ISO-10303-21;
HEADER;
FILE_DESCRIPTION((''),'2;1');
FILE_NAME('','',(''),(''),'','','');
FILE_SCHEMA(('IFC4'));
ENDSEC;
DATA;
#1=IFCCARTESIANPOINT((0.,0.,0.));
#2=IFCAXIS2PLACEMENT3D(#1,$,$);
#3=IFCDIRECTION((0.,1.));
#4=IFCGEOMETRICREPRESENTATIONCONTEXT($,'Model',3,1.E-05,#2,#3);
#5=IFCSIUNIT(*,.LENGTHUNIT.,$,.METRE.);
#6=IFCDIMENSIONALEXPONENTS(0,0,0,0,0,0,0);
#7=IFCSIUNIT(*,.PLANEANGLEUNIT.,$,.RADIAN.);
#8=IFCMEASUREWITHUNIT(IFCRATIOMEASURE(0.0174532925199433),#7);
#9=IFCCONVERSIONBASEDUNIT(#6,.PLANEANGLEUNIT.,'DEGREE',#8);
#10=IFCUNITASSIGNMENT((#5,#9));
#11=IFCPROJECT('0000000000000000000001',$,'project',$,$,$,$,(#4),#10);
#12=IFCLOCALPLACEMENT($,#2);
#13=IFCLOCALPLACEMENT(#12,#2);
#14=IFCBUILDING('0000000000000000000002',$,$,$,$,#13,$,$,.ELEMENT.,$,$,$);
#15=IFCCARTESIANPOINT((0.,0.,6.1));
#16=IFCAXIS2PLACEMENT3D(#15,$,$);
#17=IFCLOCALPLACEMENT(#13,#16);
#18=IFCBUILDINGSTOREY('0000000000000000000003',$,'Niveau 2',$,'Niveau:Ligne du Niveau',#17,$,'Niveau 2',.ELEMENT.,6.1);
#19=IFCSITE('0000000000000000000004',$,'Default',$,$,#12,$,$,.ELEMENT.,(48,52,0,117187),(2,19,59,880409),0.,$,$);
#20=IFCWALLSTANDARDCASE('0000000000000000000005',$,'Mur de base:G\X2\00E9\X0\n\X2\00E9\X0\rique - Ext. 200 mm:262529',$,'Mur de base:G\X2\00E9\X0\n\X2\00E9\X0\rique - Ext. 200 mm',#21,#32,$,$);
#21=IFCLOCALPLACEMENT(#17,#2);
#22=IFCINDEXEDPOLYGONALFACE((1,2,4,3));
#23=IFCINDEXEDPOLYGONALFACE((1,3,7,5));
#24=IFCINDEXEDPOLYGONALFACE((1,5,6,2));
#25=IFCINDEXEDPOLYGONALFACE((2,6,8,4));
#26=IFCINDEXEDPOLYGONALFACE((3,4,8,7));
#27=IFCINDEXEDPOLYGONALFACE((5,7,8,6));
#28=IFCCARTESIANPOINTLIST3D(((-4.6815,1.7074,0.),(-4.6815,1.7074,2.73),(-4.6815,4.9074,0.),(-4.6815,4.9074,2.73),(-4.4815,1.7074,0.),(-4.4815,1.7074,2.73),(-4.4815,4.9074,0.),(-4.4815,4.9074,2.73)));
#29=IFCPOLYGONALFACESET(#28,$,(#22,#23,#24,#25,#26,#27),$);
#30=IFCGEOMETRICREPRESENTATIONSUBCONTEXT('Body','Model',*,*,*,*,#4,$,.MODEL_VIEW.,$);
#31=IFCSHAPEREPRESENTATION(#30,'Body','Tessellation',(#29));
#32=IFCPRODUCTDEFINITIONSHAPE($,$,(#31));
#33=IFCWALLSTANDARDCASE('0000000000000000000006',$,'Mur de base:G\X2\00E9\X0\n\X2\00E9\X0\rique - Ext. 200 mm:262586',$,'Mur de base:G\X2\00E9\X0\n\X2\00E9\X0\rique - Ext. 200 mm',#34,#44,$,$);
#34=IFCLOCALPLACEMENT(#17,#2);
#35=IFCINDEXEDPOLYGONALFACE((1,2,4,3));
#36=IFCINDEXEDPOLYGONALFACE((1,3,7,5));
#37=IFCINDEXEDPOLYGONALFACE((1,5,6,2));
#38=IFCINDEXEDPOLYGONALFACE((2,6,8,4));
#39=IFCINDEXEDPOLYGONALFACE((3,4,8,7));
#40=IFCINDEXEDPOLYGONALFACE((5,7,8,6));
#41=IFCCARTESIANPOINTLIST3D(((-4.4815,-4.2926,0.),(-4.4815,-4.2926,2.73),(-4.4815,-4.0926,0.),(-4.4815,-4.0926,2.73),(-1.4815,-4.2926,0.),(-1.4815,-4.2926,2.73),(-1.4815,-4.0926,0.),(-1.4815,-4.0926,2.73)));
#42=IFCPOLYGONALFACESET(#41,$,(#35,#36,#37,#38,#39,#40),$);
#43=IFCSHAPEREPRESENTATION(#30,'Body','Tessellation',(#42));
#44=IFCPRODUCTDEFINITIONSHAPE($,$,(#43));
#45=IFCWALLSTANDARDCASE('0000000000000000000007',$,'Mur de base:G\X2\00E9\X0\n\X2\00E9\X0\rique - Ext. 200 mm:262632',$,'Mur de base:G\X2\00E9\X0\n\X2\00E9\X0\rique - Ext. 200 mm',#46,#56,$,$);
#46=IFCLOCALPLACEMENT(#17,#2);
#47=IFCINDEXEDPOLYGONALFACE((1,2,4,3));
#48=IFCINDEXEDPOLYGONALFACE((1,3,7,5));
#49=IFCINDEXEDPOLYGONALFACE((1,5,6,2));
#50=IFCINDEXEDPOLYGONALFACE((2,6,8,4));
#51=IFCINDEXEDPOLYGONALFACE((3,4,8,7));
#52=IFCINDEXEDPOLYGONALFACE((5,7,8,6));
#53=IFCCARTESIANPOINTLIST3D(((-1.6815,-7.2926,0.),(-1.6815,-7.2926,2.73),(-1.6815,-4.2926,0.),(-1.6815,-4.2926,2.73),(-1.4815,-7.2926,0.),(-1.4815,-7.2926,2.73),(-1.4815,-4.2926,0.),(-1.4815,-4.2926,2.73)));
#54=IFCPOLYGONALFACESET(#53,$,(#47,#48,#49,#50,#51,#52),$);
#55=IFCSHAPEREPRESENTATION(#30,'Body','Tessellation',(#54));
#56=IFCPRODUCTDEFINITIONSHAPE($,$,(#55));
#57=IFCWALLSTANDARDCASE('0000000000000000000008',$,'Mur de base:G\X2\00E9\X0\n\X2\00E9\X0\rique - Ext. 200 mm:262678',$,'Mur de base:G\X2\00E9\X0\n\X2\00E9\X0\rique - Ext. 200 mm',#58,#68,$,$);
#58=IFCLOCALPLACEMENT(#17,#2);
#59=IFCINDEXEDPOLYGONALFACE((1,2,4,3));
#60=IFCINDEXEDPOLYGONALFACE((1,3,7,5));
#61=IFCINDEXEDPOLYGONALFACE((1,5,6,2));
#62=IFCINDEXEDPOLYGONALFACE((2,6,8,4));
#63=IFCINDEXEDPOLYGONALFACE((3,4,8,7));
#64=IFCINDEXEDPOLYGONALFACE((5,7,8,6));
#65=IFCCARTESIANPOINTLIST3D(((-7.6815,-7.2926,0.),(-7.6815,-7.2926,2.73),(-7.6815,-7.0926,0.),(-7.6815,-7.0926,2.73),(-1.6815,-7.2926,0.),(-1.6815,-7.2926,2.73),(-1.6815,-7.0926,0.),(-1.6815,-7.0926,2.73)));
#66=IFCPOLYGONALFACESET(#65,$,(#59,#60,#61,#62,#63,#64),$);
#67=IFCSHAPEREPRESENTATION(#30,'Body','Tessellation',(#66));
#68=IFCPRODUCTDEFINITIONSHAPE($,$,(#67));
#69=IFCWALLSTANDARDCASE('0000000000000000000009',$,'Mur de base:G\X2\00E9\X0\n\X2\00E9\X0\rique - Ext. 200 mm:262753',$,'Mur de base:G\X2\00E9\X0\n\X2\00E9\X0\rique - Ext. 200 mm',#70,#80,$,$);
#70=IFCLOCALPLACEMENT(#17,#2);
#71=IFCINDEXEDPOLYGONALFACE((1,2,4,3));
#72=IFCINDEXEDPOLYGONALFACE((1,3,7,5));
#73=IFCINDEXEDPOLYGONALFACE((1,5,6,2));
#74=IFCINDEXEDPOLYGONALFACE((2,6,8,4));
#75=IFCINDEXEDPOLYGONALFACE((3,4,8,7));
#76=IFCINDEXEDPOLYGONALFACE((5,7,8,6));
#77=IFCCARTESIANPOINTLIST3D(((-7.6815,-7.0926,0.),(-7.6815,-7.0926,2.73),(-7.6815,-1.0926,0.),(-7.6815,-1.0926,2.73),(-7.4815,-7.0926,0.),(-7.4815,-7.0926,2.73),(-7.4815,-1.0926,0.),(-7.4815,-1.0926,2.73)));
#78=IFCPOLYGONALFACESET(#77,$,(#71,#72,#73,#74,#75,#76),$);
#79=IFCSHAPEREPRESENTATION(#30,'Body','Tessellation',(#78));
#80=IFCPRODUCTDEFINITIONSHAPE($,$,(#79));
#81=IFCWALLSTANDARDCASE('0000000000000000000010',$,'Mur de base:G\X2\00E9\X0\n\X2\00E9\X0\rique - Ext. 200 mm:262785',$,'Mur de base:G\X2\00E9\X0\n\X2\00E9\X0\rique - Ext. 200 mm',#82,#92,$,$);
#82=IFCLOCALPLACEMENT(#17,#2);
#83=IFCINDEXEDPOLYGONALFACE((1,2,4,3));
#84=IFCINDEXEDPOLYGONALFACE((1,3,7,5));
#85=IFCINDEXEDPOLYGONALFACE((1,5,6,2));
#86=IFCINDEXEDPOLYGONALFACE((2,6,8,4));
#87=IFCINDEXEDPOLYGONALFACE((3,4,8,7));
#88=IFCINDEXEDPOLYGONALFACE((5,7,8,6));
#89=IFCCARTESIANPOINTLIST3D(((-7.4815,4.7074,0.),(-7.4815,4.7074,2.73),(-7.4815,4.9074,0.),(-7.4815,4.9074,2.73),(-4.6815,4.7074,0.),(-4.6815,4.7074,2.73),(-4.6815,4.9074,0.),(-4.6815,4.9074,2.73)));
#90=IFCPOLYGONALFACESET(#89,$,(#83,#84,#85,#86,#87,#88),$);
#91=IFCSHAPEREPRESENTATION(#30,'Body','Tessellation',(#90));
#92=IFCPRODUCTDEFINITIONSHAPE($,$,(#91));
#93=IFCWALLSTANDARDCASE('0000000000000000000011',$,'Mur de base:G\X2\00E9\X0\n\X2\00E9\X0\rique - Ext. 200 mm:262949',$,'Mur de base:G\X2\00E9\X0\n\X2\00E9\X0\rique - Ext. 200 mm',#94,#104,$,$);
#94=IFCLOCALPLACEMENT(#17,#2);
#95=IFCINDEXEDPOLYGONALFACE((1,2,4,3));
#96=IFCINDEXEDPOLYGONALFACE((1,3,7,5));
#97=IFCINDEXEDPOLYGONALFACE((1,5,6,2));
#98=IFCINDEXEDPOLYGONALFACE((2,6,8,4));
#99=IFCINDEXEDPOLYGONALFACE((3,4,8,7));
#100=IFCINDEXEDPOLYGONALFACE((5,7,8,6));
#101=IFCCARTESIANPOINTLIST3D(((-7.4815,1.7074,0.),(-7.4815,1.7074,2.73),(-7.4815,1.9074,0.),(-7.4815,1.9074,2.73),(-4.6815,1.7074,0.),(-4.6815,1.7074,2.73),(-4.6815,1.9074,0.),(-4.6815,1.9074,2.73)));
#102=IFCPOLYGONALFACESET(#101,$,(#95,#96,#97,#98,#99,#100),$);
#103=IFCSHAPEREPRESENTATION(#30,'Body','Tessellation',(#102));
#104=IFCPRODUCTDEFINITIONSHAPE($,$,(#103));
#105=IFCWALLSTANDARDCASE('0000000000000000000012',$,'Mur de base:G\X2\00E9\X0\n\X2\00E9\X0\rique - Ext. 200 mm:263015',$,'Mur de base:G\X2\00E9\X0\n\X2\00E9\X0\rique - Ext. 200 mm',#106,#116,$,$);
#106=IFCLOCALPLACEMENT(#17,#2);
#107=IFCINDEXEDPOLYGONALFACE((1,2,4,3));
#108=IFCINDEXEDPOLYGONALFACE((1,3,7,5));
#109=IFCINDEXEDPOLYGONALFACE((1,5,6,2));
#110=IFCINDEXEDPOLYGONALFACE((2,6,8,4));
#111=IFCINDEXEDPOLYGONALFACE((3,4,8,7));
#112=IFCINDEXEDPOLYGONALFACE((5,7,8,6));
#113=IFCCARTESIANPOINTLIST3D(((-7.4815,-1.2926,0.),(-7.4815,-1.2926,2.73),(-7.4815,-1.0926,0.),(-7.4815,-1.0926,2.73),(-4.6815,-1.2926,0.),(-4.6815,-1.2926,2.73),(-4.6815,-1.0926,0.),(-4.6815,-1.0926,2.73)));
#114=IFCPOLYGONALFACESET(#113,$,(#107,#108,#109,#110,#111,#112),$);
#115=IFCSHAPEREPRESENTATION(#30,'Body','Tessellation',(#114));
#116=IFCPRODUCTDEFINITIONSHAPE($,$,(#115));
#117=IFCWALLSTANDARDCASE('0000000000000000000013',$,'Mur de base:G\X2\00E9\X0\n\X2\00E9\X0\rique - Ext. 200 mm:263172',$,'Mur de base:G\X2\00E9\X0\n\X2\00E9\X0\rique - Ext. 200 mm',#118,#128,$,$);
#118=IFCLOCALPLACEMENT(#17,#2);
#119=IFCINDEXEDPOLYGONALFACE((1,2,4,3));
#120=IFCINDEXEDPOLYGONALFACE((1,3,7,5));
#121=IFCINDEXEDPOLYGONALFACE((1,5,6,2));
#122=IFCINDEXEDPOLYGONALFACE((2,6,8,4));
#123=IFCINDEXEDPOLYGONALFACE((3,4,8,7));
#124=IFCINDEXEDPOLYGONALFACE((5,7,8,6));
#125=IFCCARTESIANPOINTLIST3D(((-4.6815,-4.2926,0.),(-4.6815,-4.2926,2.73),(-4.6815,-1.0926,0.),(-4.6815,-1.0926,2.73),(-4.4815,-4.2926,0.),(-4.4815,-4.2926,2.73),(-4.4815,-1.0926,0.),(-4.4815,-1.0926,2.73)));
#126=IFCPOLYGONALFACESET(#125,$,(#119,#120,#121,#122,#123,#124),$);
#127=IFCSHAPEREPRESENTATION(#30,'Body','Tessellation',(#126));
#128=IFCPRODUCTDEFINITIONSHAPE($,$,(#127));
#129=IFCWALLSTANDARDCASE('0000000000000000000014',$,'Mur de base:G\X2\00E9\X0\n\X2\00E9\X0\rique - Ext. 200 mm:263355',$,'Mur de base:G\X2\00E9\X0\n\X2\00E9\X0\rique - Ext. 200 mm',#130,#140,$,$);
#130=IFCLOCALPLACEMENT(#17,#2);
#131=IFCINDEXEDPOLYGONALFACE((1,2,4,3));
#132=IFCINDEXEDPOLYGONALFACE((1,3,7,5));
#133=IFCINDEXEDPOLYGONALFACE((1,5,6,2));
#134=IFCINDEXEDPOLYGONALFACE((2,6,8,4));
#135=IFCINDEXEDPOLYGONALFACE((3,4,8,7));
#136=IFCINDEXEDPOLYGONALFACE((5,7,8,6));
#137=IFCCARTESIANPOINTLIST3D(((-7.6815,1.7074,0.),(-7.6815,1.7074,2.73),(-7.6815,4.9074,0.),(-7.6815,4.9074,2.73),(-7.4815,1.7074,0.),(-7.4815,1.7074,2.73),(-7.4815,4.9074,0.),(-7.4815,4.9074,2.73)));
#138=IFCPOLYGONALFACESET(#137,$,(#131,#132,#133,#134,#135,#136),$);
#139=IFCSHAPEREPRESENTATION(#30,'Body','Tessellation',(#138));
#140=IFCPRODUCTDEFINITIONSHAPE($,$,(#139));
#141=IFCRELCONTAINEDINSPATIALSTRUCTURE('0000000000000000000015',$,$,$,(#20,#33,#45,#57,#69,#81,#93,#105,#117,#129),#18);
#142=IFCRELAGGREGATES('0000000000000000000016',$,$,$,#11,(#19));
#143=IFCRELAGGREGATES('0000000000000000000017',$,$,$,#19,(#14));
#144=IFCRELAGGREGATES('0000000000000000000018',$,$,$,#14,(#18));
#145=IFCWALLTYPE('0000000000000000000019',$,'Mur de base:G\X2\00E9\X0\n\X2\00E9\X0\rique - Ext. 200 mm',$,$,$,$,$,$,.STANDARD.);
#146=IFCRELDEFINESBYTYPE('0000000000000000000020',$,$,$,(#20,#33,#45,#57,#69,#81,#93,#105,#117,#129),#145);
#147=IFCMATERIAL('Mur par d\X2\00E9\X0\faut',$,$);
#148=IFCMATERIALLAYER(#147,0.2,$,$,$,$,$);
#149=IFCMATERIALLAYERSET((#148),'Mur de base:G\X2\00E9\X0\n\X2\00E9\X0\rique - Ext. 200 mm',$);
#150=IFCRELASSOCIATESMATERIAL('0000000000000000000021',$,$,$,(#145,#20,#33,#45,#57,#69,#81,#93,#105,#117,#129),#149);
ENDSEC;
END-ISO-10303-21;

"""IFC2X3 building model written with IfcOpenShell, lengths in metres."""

from ifc_helpers import new_model, entity, si_unit, converted_unit, direction, frame, frame_2d, origin, place, context, subcontext, project, spatial, polyline, rectangle, extrude, clip, bounded_halfspace, material, layer, layer_set, layer_usage, type_object, element, save


model = new_model("IFC2X3")

# Units and contexts
model_context = context("Model", 3, precision=1e-05, world=origin(), true_north=direction((0.0, 1.0)))
body_context = subcontext(model_context, "Body", "Model", "MODEL_VIEW")
ifc_project = project(units=[si_unit("LENGTHUNIT", "METRE"), converted_unit("PLANEANGLEUNIT", "DEGREE", entity("IfcRatioMeasure", 0.0174532925199433), si_unit("PLANEANGLEUNIT", "RADIAN"), dimensions=[0, 0, 0, 0, 0, 0, 0])], contexts=[model_context])

# Site, building, storey
site_placement = place(None, origin())
site = spatial("IfcSite", under=ifc_project, at=site_placement, Name="Default", CompositionType="ELEMENT", RefLatitude=(48, 52, 0, 117187), RefLongitude=(2, 19, 59, 880409), RefElevation=0.0)
building_placement = place(site_placement, origin())
building = spatial("IfcBuilding", under=site, at=building_placement, CompositionType="ELEMENT")
storey_placement = place(building_placement, frame((0.0, 0.0, 6.1)))
storey = spatial("IfcBuildingStorey", under=building, at=storey_placement, Name="Niveau 2", ObjectType="Niveau:Ligne du Niveau", LongName="Niveau 2", CompositionType="ELEMENT", Elevation=6.1)

# Walls
ifc_material_1 = material(Name="Mur par défaut")
ifc_layer_1 = layer(ifc_material_1, 0.2)
ifc_layer_set_1 = layer_set([ifc_layer_1], Name="Mur de base:Générique - Ext. 200 mm")
ifc_layer_usage_1 = layer_usage(ifc_layer_set_1, "AXIS2", "NEGATIVE", 0.1)
wall_type = type_object("IfcWallType", Name="Mur de base:Générique - Ext. 200 mm", PredefinedType="STANDARD", material=ifc_layer_set_1)
wall_1_placement = place(storey_placement, frame((-4.5815, 4.9074, 0.0), z_axis=(0.0, 0.0, 1.0), x_axis=(0.0, -1.0, 0.0)))
element("IfcWallStandardCase", 1, at=wall_1_placement, inside=storey, type_object=wall_type, material=ifc_layer_usage_1, Name="Mur de base:Générique - Ext. 200 mm:262529", ObjectType="Mur de base:Générique - Ext. 200 mm", context=body_context, shape_type="Clipping", body=[
    clip(extrude(rectangle(XDim=3.2, YDim=0.2, at=frame_2d((1.6, 0.0), x_axis=(-1.0, 0.0))), origin(), (0.0, 0.0, 1.0), 2.73), bounded_halfspace(frame((0.0, -0.1, 2.73), z_axis=(0.0, 0.0, -1.0), x_axis=(1.0, 0.0, 0.0)), True, frame((0.0, -0.1, 2.73)), polyline([(0.0, 0.0), (0.2, 0.0), (3.0, 0.0), (3.2, 0.0), (3.2, 0.2), (0.0, 0.2), (0.0, 0.0)]))),
])
ifc_layer_usage_2 = layer_usage(ifc_layer_set_1, "AXIS2", "NEGATIVE", 0.1)
wall_2_placement = place(storey_placement, frame((-4.4815, -4.1926, 0.0)))
element("IfcWallStandardCase", 2, at=wall_2_placement, inside=storey, type_object=wall_type, material=ifc_layer_usage_2, Name="Mur de base:Générique - Ext. 200 mm:262586", ObjectType="Mur de base:Générique - Ext. 200 mm", context=body_context, shape_type="Clipping", body=[
    clip(extrude(rectangle(XDim=3.0, YDim=0.2, at=frame_2d((1.5, 0.0), x_axis=(-1.0, 0.0))), origin(), (0.0, 0.0, 1.0), 2.73), bounded_halfspace(frame((0.0, -0.1, 2.73), z_axis=(0.0, 0.0, -1.0), x_axis=(0.0, -1.0, 0.0)), True, frame((0.0, -0.1, 2.73)), polyline([(0.0, 0.0), (2.8, 0.0), (3.0, 0.0), (3.0, 0.2), (1.4, 0.2), (0.0, 0.2), (0.0, 0.0)]))),
])
ifc_layer_usage_3 = layer_usage(ifc_layer_set_1, "AXIS2", "NEGATIVE", 0.1)
wall_3_placement = place(storey_placement, frame((-1.5815, -4.2926, 0.0), z_axis=(0.0, 0.0, 1.0), x_axis=(0.0, -1.0, 0.0)))
element("IfcWallStandardCase", 3, at=wall_3_placement, inside=storey, type_object=wall_type, material=ifc_layer_usage_3, Name="Mur de base:Générique - Ext. 200 mm:262632", ObjectType="Mur de base:Générique - Ext. 200 mm", context=body_context, shape_type="Clipping", body=[
    clip(extrude(rectangle(XDim=3.0, YDim=0.2, at=frame_2d((1.5, 0.0), x_axis=(-1.0, 0.0))), origin(), (0.0, 0.0, 1.0), 2.73), bounded_halfspace(frame((0.0, -0.1, 2.73), z_axis=(0.0, 0.0, -1.0), x_axis=(1.0, 0.0, 0.0)), True, frame((0.0, -0.1, 2.73)), polyline([(0.0, 0.0), (2.8, 0.0), (3.0, 0.0), (3.0, 0.2), (0.0, 0.2), (0.0, 0.0)]))),
])
ifc_layer_usage_4 = layer_usage(ifc_layer_set_1, "AXIS2", "NEGATIVE", 0.1)
wall_4_placement = place(storey_placement, frame((-1.6815, -7.1926, 0.0), z_axis=(0.0, 0.0, 1.0), x_axis=(-1.0, 0.0, 0.0)))
element("IfcWallStandardCase", 4, at=wall_4_placement, inside=storey, type_object=wall_type, material=ifc_layer_usage_4, Name="Mur de base:Générique - Ext. 200 mm:262678", ObjectType="Mur de base:Générique - Ext. 200 mm", context=body_context, shape_type="Clipping", body=[
    clip(extrude(rectangle(XDim=6.0, YDim=0.2, at=frame_2d((3.0, 0.0), x_axis=(-1.0, 0.0))), origin(), (0.0, 0.0, 1.0), 2.73), bounded_halfspace(frame((0.0, -0.1, 2.73), z_axis=(0.0, 0.0, -1.0), x_axis=(0.0, 1.0, 0.0)), True, frame((0.0, -0.1, 2.73)), polyline([(0.0, 0.0), (5.8, 0.0), (6.0, 0.0), (6.0, 0.2), (0.0, 0.2), (0.0, 0.0)]))),
])
ifc_layer_usage_5 = layer_usage(ifc_layer_set_1, "AXIS2", "NEGATIVE", 0.1)
wall_5_placement = place(storey_placement, frame((-7.5815, -7.0926, 0.0), z_axis=(0.0, 0.0, 1.0), x_axis=(0.0, 1.0, 0.0)))
element("IfcWallStandardCase", 5, at=wall_5_placement, inside=storey, type_object=wall_type, material=ifc_layer_usage_5, Name="Mur de base:Générique - Ext. 200 mm:262753", ObjectType="Mur de base:Générique - Ext. 200 mm", context=body_context, shape_type="Clipping", body=[
    clip(extrude(rectangle(XDim=6.0, YDim=0.2, at=frame_2d((3.0, 0.0), x_axis=(-1.0, 0.0))), origin(), (0.0, 0.0, 1.0), 2.73), bounded_halfspace(frame((0.0, -0.1, 2.73), z_axis=(0.0, 0.0, -1.0), x_axis=(-1.0, 0.0, 0.0)), True, frame((0.0, -0.1, 2.73)), polyline([(0.0, 0.0), (5.8, 0.0), (6.0, 0.0), (6.0, 0.2), (0.0, 0.2), (0.0, 0.0)]))),
])
ifc_layer_usage_6 = layer_usage(ifc_layer_set_1, "AXIS2", "NEGATIVE", 0.1)
wall_6_placement = place(storey_placement, frame((-7.4815, 4.8074, 0.0)))
element("IfcWallStandardCase", 6, at=wall_6_placement, inside=storey, type_object=wall_type, material=ifc_layer_usage_6, Name="Mur de base:Générique - Ext. 200 mm:262785", ObjectType="Mur de base:Générique - Ext. 200 mm", context=body_context, shape_type="Clipping", body=[
    clip(extrude(rectangle(XDim=2.8, YDim=0.2, at=frame_2d((1.4, 0.0), x_axis=(-1.0, 0.0))), origin(), (0.0, 0.0, 1.0), 2.73), bounded_halfspace(frame((0.0, -0.1, 2.73), z_axis=(0.0, 0.0, -1.0), x_axis=(0.0, -1.0, 0.0)), True, frame((0.0, -0.1, 2.73)), polyline([(0.0, 0.0), (2.8, 0.0), (2.8, 0.2), (0.0, 0.2), (0.0, 0.0)]))),
])
ifc_layer_usage_7 = layer_usage(ifc_layer_set_1, "AXIS2", "NEGATIVE", 0.1)
wall_7_placement = place(storey_placement, frame((-7.4815, 1.8074, 0.0)))
element("IfcWallStandardCase", 7, at=wall_7_placement, inside=storey, type_object=wall_type, material=ifc_layer_usage_7, Name="Mur de base:Générique - Ext. 200 mm:262949", ObjectType="Mur de base:Générique - Ext. 200 mm", context=body_context, shape_type="Clipping", body=[
    clip(extrude(rectangle(XDim=2.8, YDim=0.2, at=frame_2d((1.4, 0.0), x_axis=(-1.0, 0.0))), origin(), (0.0, 0.0, 1.0), 2.73), bounded_halfspace(frame((0.0, -0.1, 2.73), z_axis=(0.0, 0.0, -1.0), x_axis=(0.0, -1.0, 0.0)), True, frame((0.0, -0.1, 2.73)), polyline([(0.0, 0.0), (2.8, 0.0), (2.8, 0.2), (0.0, 0.2), (0.0, 0.0)]))),
])
ifc_layer_usage_8 = layer_usage(ifc_layer_set_1, "AXIS2", "NEGATIVE", 0.1)
wall_8_placement = place(storey_placement, frame((-7.4815, -1.1926, 0.0)))
element("IfcWallStandardCase", 8, at=wall_8_placement, inside=storey, type_object=wall_type, material=ifc_layer_usage_8, Name="Mur de base:Générique - Ext. 200 mm:263015", ObjectType="Mur de base:Générique - Ext. 200 mm", context=body_context, shape_type="Clipping", body=[
    clip(extrude(rectangle(XDim=2.8, YDim=0.2, at=frame_2d((1.4, 0.0), x_axis=(-1.0, 0.0))), origin(), (0.0, 0.0, 1.0), 2.73), bounded_halfspace(frame((0.0, -0.1, 2.73), z_axis=(0.0, 0.0, -1.0), x_axis=(0.0, -1.0, 0.0)), True, frame((0.0, -0.1, 2.73)), polyline([(0.0, 0.0), (2.8, 0.0), (2.8, 0.2), (0.0, 0.2), (0.0, 0.0)]))),
])
ifc_layer_usage_9 = layer_usage(ifc_layer_set_1, "AXIS2", "NEGATIVE", 0.1)
wall_9_placement = place(storey_placement, frame((-4.5815, -1.0926, 0.0), z_axis=(0.0, 0.0, 1.0), x_axis=(0.0, -1.0, 0.0)))
element("IfcWallStandardCase", 9, at=wall_9_placement, inside=storey, type_object=wall_type, material=ifc_layer_usage_9, Name="Mur de base:Générique - Ext. 200 mm:263172", ObjectType="Mur de base:Générique - Ext. 200 mm", context=body_context, shape_type="Clipping", body=[
    clip(extrude(rectangle(XDim=3.2, YDim=0.2, at=frame_2d((1.6, 0.0), x_axis=(-1.0, 0.0))), origin(), (0.0, 0.0, 1.0), 2.73), bounded_halfspace(frame((0.0, -0.1, 2.73), z_axis=(0.0, 0.0, -1.0), x_axis=(1.0, 0.0, 0.0)), True, frame((0.0, -0.1, 2.73)), polyline([(0.0, 0.0), (0.2, 0.0), (3.2, 0.0), (3.2, 0.2), (3.0, 0.2), (0.0, 0.2), (0.0, 0.0)]))),
])
ifc_layer_usage_10 = layer_usage(ifc_layer_set_1, "AXIS2", "NEGATIVE", 0.1)
wall_10_placement = place(storey_placement, frame((-7.5815, 1.7074, 0.0), z_axis=(0.0, 0.0, 1.0), x_axis=(0.0, 1.0, 0.0)))
element("IfcWallStandardCase", 10, at=wall_10_placement, inside=storey, type_object=wall_type, material=ifc_layer_usage_10, Name="Mur de base:Générique - Ext. 200 mm:263355", ObjectType="Mur de base:Générique - Ext. 200 mm", context=body_context, shape_type="Clipping", body=[
    clip(extrude(rectangle(XDim=3.2, YDim=0.2, at=frame_2d((1.6, 0.0), x_axis=(-1.0, 0.0))), origin(), (0.0, 0.0, 1.0), 2.73), bounded_halfspace(frame((0.0, -0.1, 2.73), z_axis=(0.0, 0.0, -1.0), x_axis=(-1.0, 0.0, 0.0)), True, frame((0.0, -0.1, 2.73)), polyline([(0.0, 0.0), (0.2, 0.0), (3.0, 0.0), (3.2, 0.0), (3.2, 0.2), (0.0, 0.2), (0.0, 0.0)]))),
])

save(model, "model.ifc")
